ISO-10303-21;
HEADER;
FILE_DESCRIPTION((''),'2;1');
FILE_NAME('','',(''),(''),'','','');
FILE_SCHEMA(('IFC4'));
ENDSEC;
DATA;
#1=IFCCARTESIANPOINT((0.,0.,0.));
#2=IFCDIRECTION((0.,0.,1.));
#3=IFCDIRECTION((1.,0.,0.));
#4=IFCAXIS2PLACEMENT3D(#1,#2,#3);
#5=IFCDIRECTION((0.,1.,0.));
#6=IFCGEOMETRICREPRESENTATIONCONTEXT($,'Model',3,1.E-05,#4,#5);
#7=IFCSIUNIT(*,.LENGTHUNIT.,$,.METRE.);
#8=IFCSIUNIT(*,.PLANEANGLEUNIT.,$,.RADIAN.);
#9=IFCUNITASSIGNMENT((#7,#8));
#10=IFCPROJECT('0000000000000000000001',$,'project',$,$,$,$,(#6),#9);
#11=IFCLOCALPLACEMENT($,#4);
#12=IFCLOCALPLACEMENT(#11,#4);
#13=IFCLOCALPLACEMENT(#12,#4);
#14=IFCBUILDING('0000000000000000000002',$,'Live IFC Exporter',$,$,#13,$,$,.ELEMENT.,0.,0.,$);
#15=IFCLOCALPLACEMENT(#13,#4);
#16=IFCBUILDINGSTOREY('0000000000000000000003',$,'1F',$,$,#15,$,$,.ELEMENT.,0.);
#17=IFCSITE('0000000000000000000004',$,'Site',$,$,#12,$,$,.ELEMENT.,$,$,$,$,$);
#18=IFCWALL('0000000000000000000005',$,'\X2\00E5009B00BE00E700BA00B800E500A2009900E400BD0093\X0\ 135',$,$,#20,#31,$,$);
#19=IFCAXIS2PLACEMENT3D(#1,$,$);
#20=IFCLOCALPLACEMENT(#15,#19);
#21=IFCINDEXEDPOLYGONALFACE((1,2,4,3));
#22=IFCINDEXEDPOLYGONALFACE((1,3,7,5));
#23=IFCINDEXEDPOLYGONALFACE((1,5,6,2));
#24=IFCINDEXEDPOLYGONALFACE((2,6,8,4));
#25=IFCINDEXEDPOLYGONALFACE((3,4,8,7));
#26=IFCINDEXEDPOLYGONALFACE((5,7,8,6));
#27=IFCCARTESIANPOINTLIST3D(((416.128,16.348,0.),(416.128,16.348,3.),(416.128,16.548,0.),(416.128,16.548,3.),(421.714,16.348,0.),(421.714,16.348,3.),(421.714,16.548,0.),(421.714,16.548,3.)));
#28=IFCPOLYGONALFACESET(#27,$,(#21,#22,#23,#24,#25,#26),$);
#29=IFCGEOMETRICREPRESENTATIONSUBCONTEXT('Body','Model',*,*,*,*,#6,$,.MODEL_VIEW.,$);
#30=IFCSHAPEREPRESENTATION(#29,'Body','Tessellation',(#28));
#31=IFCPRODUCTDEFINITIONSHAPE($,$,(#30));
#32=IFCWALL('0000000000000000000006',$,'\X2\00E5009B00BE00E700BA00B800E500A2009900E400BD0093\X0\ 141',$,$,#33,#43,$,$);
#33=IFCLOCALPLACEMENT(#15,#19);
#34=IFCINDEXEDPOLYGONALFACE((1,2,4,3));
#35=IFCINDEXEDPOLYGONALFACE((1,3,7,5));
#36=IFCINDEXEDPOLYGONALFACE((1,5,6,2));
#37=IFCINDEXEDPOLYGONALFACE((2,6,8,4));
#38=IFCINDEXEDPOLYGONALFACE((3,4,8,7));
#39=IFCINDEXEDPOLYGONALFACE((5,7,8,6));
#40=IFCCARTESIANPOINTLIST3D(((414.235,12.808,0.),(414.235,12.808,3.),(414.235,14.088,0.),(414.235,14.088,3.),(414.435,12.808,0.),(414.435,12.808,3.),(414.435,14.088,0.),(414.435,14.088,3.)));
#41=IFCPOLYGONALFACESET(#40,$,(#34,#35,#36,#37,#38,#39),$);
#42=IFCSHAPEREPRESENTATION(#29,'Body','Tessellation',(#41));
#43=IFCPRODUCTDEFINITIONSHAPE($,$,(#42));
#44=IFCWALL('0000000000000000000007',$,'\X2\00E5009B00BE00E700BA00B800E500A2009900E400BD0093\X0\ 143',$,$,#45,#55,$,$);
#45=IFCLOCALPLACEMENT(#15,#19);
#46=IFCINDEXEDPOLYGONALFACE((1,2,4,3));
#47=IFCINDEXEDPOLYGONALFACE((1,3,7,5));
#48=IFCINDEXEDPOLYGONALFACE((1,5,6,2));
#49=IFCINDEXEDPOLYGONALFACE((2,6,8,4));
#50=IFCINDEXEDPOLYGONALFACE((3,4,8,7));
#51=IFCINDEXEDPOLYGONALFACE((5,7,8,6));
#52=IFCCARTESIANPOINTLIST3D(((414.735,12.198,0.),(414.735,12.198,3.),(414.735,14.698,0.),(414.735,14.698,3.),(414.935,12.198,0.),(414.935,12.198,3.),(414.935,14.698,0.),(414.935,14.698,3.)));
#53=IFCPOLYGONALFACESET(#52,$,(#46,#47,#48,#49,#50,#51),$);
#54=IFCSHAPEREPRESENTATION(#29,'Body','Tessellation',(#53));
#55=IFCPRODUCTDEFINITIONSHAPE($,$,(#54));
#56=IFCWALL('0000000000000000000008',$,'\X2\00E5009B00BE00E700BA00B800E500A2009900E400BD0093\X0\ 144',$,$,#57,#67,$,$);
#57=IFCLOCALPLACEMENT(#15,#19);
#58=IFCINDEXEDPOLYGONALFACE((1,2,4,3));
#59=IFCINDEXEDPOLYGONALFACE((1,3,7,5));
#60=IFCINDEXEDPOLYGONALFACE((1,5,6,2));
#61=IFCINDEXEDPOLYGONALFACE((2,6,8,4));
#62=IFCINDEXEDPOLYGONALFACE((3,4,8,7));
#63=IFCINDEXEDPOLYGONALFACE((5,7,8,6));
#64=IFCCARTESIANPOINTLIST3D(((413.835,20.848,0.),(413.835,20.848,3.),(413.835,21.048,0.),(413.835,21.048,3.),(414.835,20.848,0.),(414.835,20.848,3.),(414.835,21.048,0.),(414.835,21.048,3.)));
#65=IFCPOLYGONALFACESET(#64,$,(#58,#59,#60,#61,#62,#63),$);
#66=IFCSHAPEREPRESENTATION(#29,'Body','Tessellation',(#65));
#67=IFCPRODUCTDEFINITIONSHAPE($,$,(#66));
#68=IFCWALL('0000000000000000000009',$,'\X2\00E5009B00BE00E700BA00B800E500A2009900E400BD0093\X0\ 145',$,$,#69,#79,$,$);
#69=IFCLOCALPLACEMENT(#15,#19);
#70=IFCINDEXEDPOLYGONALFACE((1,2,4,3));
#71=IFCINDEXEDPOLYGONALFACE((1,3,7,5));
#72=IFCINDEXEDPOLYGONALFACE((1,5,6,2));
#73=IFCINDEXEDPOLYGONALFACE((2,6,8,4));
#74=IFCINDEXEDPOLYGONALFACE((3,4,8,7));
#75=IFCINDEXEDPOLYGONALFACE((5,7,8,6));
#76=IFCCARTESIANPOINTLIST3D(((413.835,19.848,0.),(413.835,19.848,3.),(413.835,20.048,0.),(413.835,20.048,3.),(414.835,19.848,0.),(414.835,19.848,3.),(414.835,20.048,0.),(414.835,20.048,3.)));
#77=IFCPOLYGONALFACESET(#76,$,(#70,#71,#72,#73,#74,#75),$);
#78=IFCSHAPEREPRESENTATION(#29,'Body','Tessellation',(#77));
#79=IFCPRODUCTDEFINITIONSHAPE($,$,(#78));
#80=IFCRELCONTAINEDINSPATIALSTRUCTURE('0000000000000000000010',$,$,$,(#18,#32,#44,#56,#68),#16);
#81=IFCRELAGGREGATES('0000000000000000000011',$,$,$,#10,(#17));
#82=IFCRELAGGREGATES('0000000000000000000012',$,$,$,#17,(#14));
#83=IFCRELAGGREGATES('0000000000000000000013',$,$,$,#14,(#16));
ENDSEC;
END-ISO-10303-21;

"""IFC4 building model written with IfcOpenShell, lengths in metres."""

from ifc_helpers import new_model, si_unit, direction, frame, frame_2d, origin_with_axes, place, context, subcontext, project, spatial, rectangle, extrude, element, save


model = new_model("IFC4")

# Units and contexts
model_context = context("Model", 3, precision=1e-05, world=origin_with_axes(), true_north=direction((0.0, 1.0, 0.0)))
body_context = subcontext(model_context, "Body", "Model", "MODEL_VIEW")
ifc_project = project(units=[si_unit("LENGTHUNIT", "METRE"), si_unit("PLANEANGLEUNIT", "RADIAN")], contexts=[model_context])

# Site, building, storey
placement = place(None, origin_with_axes())
site_placement = place(placement, origin_with_axes())
site = spatial("IfcSite", under=ifc_project, at=site_placement, Name="Site", CompositionType="ELEMENT")
building_placement = place(site_placement, origin_with_axes())
building = spatial("IfcBuilding", under=site, at=building_placement, Name="Live IFC Exporter", CompositionType="ELEMENT", ElevationOfRefHeight=0.0, ElevationOfTerrain=0.0)
storey_placement = place(building_placement, origin_with_axes())
storey = spatial("IfcBuildingStorey", under=building, at=storey_placement, Name="1F", CompositionType="ELEMENT", Elevation=0.0)

# Walls
wall_1_placement = place(storey_placement, frame((418.921, 16.448, 0.0), z_axis=(0.0, 0.0, 1.0), x_axis=(-1.0, 0.0, 0.0)))
element("IfcWall", 1, at=wall_1_placement, inside=storey, Name="å\u009b¾çº¸å¢\u0099ä½\u0093 135", context=body_context, shape_type="SweptSolid", body=[
    extrude(rectangle(XDim=5.586, YDim=0.2, at=frame_2d((0.0, 0.0), x_axis=(1.0, 0.0, 0.0))), frame((0.0, 0.0, 0.0), z_axis=(0.0, 0.0, 1.0)), (0.0, 0.0, 1.0), 3.0),
])
wall_2_placement = place(storey_placement, frame((414.335, 13.448, 0.0), z_axis=(0.0, 0.0, 1.0), x_axis=(0.0, -1.0, 0.0)))
element("IfcWall", 2, at=wall_2_placement, inside=storey, Name="å\u009b¾çº¸å¢\u0099ä½\u0093 141", context=body_context, shape_type="SweptSolid", body=[
    extrude(rectangle(XDim=1.28, YDim=0.2, at=frame_2d((0.0, 0.0), x_axis=(1.0, 0.0, 0.0))), frame((0.0, 0.0, 0.0), z_axis=(0.0, 0.0, 1.0)), (0.0, 0.0, 1.0), 3.0),
])
wall_3_placement = place(storey_placement, frame((414.835, 13.448, 0.0), z_axis=(0.0, 0.0, 1.0), x_axis=(0.0, 1.0, 0.0)))
element("IfcWall", 3, at=wall_3_placement, inside=storey, Name="å\u009b¾çº¸å¢\u0099ä½\u0093 143", context=body_context, shape_type="SweptSolid", body=[
    extrude(rectangle(XDim=2.5, YDim=0.2, at=frame_2d((0.0, 0.0), x_axis=(1.0, 0.0, 0.0))), frame((0.0, 0.0, 0.0), z_axis=(0.0, 0.0, 1.0)), (0.0, 0.0, 1.0), 3.0),
])
for number, where, z_axis, x_axis, name in (
    (4, (414.335, 20.948, 0.0), (0.0, 0.0, 1.0), (-1.0, 0.0, 0.0), "å\u009b¾çº¸å¢\u0099ä½\u0093 144"),
    (5, (414.335, 19.948, 0.0), (0.0, 0.0, 1.0), (-1.0, 0.0, 0.0), "å\u009b¾çº¸å¢\u0099ä½\u0093 145"),
):
    element("IfcWall", number, at=place(storey_placement, frame(where, z_axis=z_axis, x_axis=x_axis)), inside=storey, Name=name, context=body_context, shape_type="SweptSolid", body=[
        extrude(rectangle(XDim=1.0, YDim=0.2, at=frame_2d((0.0, 0.0), x_axis=(1.0, 0.0, 0.0))), frame((0.0, 0.0, 0.0), z_axis=(0.0, 0.0, 1.0)), (0.0, 0.0, 1.0), 3.0),
    ])

save(model, "model.ifc")
